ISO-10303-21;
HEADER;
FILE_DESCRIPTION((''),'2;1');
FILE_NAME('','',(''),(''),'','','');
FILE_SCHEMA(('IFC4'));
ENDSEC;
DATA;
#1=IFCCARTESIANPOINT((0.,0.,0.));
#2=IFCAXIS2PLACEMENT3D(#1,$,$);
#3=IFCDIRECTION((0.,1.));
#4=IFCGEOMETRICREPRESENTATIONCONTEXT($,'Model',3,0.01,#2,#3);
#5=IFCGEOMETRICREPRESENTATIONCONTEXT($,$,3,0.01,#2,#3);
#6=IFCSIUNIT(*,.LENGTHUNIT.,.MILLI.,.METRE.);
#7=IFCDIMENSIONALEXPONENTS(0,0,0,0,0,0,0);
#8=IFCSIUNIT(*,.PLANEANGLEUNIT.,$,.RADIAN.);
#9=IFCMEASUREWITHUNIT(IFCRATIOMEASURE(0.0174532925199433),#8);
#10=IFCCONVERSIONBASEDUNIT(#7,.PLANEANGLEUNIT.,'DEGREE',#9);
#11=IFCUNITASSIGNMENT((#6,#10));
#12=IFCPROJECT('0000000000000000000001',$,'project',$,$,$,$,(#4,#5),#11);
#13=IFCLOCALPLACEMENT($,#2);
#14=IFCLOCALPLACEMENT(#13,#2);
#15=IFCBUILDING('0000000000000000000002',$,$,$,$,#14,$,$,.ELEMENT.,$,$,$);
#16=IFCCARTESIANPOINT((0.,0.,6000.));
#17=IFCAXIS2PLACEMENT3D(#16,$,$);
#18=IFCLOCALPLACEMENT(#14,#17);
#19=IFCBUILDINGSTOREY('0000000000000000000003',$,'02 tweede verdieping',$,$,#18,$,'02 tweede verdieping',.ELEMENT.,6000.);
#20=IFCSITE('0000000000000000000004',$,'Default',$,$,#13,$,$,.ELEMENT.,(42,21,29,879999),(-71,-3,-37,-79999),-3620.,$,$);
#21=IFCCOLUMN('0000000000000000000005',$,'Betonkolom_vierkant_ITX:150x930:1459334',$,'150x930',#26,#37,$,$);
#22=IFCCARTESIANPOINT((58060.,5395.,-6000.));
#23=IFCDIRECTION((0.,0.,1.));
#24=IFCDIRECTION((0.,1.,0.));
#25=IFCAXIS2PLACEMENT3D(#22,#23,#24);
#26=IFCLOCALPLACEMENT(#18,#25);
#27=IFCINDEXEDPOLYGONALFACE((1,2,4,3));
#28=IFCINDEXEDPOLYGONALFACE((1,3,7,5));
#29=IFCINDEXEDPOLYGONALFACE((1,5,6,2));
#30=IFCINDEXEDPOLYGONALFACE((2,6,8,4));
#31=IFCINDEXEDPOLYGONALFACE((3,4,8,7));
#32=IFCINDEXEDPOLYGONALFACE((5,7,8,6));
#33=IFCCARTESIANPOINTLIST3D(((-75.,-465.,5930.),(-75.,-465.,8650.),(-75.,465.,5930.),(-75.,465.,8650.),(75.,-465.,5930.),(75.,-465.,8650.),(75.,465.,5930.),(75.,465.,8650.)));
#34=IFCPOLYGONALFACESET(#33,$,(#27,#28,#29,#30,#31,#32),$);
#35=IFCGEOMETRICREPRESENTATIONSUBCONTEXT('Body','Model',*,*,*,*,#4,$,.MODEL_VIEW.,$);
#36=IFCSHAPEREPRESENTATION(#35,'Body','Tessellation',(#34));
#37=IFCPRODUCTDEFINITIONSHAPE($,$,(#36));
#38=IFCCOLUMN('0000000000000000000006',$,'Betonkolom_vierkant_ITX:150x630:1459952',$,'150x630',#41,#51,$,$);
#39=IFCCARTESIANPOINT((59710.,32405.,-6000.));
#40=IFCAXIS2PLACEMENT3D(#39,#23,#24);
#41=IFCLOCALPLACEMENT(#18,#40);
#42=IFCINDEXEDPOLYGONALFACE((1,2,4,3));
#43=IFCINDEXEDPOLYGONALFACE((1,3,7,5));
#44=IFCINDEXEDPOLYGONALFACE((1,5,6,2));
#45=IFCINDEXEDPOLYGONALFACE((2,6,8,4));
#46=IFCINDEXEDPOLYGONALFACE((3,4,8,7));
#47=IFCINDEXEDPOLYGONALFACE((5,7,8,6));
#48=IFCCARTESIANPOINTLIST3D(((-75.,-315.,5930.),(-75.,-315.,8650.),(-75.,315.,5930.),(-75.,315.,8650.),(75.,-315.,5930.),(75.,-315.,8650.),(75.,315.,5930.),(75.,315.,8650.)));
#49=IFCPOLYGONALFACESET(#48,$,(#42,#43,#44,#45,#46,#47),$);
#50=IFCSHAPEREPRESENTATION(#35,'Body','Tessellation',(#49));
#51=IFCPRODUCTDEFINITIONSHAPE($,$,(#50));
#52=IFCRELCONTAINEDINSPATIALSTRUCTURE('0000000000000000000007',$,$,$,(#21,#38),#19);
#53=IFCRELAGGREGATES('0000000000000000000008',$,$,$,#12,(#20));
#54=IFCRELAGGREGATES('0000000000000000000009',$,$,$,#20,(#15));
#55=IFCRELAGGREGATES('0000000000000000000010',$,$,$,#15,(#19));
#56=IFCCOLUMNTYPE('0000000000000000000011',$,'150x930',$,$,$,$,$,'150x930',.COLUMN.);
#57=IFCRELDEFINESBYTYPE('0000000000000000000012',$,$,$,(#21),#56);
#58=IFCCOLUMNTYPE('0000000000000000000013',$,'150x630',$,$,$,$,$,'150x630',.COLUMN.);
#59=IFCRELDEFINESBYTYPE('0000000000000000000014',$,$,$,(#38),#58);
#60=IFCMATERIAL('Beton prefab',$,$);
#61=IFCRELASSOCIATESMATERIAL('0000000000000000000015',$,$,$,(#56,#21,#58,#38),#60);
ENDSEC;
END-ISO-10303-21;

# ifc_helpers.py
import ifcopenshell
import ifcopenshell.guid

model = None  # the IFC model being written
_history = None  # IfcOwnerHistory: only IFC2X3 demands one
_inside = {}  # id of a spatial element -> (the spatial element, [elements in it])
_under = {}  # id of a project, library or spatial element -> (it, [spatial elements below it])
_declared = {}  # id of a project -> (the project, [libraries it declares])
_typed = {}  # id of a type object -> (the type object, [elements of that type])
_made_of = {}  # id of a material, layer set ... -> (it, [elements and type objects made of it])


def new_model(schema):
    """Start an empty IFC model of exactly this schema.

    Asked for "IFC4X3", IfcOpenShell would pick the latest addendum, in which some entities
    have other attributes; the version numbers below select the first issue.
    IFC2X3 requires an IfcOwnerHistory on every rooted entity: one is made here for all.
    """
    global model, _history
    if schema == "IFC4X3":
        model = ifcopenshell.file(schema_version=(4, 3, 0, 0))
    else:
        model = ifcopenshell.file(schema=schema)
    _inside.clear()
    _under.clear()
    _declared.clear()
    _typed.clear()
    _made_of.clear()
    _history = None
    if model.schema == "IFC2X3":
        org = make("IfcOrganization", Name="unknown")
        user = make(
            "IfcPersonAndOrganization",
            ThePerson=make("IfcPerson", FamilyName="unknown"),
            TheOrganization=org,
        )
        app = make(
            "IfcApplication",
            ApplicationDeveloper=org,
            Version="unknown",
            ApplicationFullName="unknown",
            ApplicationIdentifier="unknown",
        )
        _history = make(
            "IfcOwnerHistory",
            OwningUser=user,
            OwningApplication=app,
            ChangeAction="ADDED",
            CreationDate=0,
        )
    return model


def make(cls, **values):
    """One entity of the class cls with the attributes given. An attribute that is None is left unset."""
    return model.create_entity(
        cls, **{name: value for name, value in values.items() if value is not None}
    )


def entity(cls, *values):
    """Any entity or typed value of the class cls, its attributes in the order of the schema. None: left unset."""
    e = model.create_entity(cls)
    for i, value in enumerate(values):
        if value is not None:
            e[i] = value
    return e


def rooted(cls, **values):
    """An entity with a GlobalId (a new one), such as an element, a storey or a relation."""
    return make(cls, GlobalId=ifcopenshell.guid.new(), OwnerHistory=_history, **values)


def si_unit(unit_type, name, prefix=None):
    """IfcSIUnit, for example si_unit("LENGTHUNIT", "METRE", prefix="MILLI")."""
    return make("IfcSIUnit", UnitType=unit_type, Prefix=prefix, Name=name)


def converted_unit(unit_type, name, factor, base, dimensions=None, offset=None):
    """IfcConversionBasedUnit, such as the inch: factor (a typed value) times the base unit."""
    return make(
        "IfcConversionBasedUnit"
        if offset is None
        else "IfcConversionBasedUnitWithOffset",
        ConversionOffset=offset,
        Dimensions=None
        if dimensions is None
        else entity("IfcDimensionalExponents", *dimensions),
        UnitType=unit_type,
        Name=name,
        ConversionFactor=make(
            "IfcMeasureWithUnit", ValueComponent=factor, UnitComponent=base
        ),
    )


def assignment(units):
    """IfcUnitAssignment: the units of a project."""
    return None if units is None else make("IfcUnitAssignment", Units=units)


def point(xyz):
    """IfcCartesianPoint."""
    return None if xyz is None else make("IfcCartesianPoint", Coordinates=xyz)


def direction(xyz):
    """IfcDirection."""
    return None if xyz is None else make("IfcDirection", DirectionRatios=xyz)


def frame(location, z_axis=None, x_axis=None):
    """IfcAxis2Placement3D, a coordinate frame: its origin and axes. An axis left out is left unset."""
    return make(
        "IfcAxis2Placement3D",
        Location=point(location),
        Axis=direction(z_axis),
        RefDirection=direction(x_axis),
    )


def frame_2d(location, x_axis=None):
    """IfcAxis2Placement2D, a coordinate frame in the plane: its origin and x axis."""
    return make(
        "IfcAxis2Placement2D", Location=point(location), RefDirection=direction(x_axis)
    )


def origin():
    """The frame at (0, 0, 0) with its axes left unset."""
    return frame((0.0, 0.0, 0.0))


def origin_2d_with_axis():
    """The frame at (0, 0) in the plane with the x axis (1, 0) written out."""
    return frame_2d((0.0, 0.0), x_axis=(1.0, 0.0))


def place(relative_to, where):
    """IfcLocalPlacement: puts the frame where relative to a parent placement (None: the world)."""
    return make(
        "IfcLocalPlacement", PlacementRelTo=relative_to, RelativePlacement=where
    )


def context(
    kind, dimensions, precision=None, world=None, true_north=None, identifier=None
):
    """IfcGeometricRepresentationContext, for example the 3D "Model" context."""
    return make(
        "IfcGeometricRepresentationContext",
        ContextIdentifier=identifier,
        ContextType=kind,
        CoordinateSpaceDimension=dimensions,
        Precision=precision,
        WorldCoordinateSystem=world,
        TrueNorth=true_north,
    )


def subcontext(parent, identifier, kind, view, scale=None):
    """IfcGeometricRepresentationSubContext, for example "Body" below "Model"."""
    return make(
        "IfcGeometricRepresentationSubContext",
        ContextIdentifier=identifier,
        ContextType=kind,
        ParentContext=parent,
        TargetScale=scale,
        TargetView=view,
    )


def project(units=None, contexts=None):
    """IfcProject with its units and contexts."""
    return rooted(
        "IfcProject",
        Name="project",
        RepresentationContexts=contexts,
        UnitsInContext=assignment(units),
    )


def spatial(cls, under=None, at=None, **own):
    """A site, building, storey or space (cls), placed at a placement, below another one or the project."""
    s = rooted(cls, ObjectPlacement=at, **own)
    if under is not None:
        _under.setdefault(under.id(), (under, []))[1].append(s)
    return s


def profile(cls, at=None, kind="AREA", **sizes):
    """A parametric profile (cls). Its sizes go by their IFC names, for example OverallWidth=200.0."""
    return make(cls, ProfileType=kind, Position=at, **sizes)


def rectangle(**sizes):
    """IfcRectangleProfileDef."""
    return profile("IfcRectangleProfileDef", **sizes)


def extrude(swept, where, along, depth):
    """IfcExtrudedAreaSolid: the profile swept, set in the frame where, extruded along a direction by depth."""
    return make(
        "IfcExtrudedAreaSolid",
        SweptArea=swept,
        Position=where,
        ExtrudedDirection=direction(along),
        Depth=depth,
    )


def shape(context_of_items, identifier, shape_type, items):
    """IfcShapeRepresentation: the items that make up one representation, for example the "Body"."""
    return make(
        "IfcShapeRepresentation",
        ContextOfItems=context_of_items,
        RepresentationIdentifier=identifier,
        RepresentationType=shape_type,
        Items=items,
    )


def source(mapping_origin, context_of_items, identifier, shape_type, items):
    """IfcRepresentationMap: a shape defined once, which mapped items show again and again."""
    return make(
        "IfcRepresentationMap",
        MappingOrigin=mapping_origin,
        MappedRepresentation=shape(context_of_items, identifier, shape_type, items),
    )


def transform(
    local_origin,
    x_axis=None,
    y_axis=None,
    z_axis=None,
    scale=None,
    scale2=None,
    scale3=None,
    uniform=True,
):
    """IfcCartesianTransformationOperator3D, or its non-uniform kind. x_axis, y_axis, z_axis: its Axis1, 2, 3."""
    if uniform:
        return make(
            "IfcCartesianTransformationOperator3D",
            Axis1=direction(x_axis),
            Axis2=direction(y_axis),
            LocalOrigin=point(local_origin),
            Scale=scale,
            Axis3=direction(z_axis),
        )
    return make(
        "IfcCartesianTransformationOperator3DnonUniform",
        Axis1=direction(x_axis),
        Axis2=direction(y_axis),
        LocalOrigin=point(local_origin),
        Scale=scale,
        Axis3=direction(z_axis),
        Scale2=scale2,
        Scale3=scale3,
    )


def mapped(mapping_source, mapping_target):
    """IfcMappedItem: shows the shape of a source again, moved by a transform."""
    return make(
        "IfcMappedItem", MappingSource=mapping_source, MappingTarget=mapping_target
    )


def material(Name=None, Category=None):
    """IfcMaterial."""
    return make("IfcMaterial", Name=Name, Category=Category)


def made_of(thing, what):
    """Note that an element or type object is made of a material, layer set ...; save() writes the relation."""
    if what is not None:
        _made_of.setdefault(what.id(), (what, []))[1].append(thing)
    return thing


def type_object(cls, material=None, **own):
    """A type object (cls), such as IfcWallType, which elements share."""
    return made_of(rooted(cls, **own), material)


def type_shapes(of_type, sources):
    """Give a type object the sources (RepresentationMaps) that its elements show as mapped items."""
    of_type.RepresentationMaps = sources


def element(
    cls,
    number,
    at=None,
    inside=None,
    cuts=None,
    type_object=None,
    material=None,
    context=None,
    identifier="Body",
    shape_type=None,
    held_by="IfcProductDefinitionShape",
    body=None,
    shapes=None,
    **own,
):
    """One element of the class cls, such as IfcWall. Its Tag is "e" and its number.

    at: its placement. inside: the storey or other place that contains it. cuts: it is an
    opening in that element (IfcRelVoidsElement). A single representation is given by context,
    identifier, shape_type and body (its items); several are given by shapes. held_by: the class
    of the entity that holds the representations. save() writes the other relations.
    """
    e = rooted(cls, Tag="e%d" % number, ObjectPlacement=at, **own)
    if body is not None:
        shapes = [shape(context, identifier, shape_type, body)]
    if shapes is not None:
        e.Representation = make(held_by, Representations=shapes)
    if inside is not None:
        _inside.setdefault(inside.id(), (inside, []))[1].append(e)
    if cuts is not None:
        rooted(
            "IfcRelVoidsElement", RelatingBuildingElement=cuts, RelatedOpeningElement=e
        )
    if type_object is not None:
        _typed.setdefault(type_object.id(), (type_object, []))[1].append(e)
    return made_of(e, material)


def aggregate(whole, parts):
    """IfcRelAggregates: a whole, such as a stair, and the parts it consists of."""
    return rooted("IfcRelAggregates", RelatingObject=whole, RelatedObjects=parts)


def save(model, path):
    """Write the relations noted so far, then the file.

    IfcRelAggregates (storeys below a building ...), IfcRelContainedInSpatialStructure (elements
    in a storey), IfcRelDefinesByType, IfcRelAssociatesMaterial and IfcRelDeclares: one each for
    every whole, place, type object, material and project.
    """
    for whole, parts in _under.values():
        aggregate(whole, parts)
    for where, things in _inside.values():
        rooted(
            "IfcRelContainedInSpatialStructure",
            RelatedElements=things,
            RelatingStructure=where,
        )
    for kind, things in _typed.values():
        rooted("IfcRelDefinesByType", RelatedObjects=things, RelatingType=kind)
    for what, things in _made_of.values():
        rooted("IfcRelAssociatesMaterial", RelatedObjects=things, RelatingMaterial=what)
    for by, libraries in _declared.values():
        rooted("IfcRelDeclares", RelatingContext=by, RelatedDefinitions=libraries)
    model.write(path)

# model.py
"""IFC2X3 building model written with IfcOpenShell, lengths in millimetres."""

from ifc_helpers import new_model, entity, si_unit, converted_unit, direction, frame, origin, origin_2d_with_axis, place, context, subcontext, project, spatial, rectangle, extrude, source, transform, mapped, material, type_object, type_shapes, element, save


model = new_model("IFC2X3")

# Units and contexts
model_context = context("Model", 3, precision=0.01, world=origin(), true_north=direction((0.0, 1.0)))
context_of_model = context(None, 3, precision=0.01, world=origin(), true_north=direction((0.0, 1.0)))
body_context = subcontext(model_context, "Body", "Model", "MODEL_VIEW")
ifc_project = project(units=[si_unit("LENGTHUNIT", "METRE", prefix="MILLI"), converted_unit("PLANEANGLEUNIT", "DEGREE", entity("IfcRatioMeasure", 0.0174532925199433), si_unit("PLANEANGLEUNIT", "RADIAN"), dimensions=[0, 0, 0, 0, 0, 0, 0])], contexts=[model_context, context_of_model])

# Site, building, storey
site_placement = place(None, origin())
site = spatial("IfcSite", under=ifc_project, at=site_placement, Name="Default", CompositionType="ELEMENT", RefLatitude=(42, 21, 29, 879999), RefLongitude=(-71, -3, -37, -79999), RefElevation=-3620.0)
building_placement = place(site_placement, origin())
building = spatial("IfcBuilding", under=site, at=building_placement, CompositionType="ELEMENT")
storey_placement = place(building_placement, frame((0.0, 0.0, 6000.0)))
storey = spatial("IfcBuildingStorey", under=building, at=storey_placement, Name="02 tweede verdieping", LongName="02 tweede verdieping", CompositionType="ELEMENT", Elevation=6000.0)

# Columns
ifc_material_1 = material(Name="Beton prefab")
column_type_1 = type_object("IfcColumnType", Name="150x930", ElementType="150x930", PredefinedType="COLUMN", material=ifc_material_1)
shared_shape_1 = source(origin(), body_context, "Body", "SweptSolid", [
    extrude(rectangle(XDim=930.0, YDim=150.0, at=origin_2d_with_axis()), frame((0.0, 0.0, 5930.0), z_axis=(0.0, 0.0, 1.0), x_axis=(0.0, -1.0, 0.0)), (0.0, 0.0, 1.0), 2720.0),
])
type_shapes(column_type_1, [shared_shape_1])
column_1_placement = place(storey_placement, frame((58060.0, 5395.0, -6000.0), z_axis=(0.0, 0.0, 1.0), x_axis=(0.0, 1.0, 0.0)))
element("IfcColumn", 1, at=column_1_placement, inside=storey, type_object=column_type_1, material=ifc_material_1, Name="Betonkolom_vierkant_ITX:150x930:1459334", ObjectType="150x930", context=body_context, shape_type="MappedRepresentation", body=[
    mapped(shared_shape_1, transform((0.0, 0.0, 0.0), scale=1.0)),
])
column_type_2 = type_object("IfcColumnType", Name="150x630", ElementType="150x630", PredefinedType="COLUMN", material=ifc_material_1)
shared_shape_2 = source(origin(), body_context, "Body", "SweptSolid", [
    extrude(rectangle(XDim=630.0, YDim=150.0, at=origin_2d_with_axis()), frame((0.0, 0.0, 5930.0), z_axis=(0.0, 0.0, 1.0), x_axis=(0.0, -1.0, 0.0)), (0.0, 0.0, 1.0), 2720.0),
])
type_shapes(column_type_2, [shared_shape_2])
column_2_placement = place(storey_placement, frame((59710.0, 32405.0, -6000.0), z_axis=(0.0, 0.0, 1.0), x_axis=(0.0, 1.0, 0.0)))
element("IfcColumn", 2, at=column_2_placement, inside=storey, type_object=column_type_2, material=ifc_material_1, Name="Betonkolom_vierkant_ITX:150x630:1459952", ObjectType="150x630", context=body_context, shape_type="MappedRepresentation", body=[
    mapped(shared_shape_2, transform((0.0, 0.0, 0.0), scale=1.0)),
])

save(model, "model.ifc")
